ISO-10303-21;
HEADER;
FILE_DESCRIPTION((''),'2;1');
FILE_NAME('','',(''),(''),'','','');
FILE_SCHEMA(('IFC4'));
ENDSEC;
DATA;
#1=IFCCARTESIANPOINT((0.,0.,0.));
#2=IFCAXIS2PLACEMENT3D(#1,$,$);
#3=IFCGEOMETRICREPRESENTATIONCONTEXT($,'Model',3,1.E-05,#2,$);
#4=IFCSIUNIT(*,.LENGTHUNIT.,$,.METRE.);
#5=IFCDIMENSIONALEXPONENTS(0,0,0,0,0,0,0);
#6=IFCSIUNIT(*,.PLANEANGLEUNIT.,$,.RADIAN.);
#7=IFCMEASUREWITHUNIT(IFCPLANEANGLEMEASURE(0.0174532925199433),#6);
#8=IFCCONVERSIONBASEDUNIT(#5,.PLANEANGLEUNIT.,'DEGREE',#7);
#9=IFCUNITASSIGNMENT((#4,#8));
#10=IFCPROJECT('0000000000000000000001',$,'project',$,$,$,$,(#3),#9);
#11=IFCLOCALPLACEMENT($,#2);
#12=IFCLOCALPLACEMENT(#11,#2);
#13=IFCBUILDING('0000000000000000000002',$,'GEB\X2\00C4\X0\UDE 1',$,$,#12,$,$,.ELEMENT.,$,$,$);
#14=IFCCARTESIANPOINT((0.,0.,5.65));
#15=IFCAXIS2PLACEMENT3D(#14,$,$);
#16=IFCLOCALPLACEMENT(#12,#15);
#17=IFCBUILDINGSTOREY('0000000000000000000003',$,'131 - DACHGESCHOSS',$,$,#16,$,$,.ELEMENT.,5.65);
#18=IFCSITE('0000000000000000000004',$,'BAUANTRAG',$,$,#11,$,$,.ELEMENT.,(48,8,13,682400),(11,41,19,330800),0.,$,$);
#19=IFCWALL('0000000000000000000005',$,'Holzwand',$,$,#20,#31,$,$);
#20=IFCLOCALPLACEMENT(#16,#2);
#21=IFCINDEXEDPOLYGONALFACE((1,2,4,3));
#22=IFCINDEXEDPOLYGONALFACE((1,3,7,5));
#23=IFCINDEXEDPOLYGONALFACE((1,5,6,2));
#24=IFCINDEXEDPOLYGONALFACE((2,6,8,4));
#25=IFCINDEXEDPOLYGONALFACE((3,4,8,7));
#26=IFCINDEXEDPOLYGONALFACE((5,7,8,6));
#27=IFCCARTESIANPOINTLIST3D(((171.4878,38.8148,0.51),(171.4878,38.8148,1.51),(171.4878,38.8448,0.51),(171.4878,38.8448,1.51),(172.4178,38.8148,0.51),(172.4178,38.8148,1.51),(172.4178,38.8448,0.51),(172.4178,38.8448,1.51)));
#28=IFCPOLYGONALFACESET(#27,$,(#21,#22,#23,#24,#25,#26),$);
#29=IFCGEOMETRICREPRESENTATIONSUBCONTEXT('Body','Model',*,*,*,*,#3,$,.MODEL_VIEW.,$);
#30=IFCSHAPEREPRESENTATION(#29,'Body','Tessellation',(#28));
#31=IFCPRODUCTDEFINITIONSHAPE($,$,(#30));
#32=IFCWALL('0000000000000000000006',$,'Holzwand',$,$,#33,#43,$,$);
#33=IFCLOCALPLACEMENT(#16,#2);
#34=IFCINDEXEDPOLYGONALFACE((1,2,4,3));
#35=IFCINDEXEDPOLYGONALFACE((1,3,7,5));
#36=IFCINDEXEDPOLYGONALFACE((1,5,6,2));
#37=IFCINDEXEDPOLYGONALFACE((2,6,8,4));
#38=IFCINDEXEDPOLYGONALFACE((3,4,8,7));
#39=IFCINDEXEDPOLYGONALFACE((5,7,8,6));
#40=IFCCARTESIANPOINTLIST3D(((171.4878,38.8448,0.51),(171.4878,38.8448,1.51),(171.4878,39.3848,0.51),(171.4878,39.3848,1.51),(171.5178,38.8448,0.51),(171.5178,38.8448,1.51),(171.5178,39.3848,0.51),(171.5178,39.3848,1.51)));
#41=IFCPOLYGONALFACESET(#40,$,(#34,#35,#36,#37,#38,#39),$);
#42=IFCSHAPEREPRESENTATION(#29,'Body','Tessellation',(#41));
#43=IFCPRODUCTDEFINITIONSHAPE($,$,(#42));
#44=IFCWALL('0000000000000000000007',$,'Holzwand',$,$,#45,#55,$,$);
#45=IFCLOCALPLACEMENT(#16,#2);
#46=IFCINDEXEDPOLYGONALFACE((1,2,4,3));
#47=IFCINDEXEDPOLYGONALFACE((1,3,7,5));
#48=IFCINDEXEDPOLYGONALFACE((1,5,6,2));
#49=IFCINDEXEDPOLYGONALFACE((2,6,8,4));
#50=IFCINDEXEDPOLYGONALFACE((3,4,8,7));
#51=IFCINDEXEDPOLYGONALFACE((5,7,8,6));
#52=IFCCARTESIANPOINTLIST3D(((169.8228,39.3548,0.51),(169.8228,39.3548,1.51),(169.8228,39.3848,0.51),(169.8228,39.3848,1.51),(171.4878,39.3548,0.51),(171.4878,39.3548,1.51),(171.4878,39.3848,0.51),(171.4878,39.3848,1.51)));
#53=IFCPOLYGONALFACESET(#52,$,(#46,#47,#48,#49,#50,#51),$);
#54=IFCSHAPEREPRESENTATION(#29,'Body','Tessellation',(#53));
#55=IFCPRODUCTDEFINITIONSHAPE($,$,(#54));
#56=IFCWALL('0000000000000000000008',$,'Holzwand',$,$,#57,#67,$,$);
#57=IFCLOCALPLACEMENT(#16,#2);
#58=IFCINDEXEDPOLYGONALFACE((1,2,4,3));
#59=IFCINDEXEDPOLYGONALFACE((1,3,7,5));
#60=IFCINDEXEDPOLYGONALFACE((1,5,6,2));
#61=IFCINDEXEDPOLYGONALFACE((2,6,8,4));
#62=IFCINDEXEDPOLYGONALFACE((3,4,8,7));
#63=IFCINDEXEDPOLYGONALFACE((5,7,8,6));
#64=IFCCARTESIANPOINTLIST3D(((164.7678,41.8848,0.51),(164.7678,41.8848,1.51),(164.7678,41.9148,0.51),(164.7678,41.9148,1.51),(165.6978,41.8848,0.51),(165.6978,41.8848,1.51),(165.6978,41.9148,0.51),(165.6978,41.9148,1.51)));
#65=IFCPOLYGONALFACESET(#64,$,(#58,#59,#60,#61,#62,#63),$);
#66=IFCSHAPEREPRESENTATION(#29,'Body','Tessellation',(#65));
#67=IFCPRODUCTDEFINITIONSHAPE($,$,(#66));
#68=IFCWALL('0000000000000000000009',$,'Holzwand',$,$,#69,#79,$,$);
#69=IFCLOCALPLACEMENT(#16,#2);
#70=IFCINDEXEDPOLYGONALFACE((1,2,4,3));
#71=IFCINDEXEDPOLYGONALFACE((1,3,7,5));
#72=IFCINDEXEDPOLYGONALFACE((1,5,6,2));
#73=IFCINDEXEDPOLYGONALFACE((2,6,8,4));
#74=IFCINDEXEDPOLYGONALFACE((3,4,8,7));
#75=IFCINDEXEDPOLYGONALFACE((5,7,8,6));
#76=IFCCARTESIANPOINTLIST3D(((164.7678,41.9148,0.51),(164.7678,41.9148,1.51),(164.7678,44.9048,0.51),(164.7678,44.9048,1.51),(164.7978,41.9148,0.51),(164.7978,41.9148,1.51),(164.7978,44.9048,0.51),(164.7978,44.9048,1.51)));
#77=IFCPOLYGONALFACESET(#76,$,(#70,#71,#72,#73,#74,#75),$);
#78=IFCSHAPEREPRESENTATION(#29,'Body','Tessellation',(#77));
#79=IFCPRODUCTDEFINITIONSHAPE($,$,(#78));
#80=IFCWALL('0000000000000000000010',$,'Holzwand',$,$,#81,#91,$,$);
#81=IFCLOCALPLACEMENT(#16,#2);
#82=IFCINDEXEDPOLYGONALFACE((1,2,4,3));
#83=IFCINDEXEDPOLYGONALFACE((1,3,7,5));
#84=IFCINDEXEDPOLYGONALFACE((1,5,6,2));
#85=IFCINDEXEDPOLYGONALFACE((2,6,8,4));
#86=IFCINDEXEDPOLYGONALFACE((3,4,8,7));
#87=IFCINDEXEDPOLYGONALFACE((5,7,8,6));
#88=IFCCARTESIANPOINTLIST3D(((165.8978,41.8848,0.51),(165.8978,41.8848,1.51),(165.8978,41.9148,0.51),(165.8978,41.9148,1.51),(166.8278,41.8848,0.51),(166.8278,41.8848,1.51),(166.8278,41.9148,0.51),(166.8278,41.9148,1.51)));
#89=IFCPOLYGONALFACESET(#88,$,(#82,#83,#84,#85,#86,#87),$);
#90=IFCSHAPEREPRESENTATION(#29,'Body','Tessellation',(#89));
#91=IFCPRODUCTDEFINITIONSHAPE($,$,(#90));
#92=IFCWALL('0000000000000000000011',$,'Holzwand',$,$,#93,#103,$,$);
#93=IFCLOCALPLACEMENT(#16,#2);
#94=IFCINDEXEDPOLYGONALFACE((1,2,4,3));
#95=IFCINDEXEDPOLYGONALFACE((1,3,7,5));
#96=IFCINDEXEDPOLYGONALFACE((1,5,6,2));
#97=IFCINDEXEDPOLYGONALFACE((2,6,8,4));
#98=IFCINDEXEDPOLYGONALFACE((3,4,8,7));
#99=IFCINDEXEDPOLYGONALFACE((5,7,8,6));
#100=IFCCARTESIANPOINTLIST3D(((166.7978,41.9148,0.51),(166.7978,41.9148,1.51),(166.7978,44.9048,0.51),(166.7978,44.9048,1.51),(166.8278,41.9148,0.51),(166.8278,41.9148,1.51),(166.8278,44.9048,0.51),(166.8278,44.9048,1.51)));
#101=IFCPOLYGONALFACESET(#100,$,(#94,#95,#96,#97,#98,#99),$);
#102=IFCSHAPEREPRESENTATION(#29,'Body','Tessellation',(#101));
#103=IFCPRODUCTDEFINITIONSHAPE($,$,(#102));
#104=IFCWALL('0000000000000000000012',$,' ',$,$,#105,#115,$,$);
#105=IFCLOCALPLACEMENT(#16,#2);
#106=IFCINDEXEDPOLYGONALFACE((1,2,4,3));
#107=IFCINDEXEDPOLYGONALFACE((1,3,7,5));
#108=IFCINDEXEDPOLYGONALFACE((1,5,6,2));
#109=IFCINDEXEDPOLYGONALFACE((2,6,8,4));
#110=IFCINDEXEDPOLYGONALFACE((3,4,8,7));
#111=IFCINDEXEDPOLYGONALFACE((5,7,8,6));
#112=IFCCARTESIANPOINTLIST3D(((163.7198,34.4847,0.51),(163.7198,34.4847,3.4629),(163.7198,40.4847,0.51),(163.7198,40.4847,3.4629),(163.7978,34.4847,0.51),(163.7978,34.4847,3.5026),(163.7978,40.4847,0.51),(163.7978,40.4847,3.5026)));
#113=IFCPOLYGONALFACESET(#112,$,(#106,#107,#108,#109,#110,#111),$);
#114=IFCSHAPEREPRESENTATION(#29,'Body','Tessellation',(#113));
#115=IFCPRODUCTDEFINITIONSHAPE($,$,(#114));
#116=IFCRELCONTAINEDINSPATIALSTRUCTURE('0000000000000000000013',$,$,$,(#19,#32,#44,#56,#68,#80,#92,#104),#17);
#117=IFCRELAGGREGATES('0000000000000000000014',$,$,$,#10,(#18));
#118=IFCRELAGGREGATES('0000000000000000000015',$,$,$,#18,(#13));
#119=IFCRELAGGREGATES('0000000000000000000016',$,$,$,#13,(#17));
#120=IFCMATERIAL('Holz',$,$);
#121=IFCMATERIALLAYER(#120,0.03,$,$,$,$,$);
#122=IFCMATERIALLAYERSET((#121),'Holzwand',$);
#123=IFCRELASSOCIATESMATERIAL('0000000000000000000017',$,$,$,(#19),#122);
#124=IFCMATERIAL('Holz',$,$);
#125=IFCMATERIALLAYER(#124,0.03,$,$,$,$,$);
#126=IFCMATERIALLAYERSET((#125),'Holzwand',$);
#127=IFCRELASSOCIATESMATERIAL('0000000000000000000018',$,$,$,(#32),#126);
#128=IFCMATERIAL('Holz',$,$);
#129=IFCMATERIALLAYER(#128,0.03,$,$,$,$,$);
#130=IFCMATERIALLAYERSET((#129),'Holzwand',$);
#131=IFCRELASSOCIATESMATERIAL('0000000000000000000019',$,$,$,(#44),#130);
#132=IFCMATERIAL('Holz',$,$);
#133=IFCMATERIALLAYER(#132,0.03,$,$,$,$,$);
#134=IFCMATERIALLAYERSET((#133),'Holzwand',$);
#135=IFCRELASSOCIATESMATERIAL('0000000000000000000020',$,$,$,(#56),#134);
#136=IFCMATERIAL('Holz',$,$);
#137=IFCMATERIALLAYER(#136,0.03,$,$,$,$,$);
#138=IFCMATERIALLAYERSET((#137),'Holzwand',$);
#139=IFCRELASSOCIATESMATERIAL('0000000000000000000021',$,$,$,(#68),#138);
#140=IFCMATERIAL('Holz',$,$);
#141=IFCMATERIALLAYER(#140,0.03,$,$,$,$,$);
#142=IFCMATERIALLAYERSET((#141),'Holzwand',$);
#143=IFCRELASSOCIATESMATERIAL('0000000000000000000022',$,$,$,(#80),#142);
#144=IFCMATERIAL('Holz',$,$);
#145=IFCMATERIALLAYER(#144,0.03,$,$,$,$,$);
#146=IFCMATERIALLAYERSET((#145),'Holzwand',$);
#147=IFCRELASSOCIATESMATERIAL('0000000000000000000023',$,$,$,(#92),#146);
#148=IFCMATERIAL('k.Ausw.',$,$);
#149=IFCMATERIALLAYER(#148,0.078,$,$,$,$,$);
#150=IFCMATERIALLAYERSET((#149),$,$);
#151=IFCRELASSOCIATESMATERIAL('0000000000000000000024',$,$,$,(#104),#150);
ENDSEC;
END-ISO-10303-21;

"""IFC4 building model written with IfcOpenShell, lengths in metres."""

from ifc_helpers import new_model, entity, si_unit, converted_unit, frame, frame_2d, origin, origin_with_axes, place, context, subcontext, project, spatial, rectangle, extrude, clip, halfspace, material, layer, layer_set, layer_usage, element, save


model = new_model("IFC4")

# Units and contexts
model_context = context("Model", 3, precision=1e-05, world=origin())
body_context = subcontext(model_context, "Body", "Model", "MODEL_VIEW")
ifc_project = project(units=[si_unit("LENGTHUNIT", "METRE"), converted_unit("PLANEANGLEUNIT", "DEGREE", entity("IfcPlaneAngleMeasure", 0.0174532925199433), si_unit("PLANEANGLEUNIT", "RADIAN"), dimensions=[0, 0, 0, 0, 0, 0, 0])], contexts=[model_context])

# Site, building, storey
site_placement = place(None, origin())
site = spatial("IfcSite", under=ifc_project, at=site_placement, Name="BAUANTRAG", CompositionType="ELEMENT", RefLatitude=(48, 8, 13, 682400), RefLongitude=(11, 41, 19, 330800), RefElevation=0.0)
building_placement = place(site_placement, origin())
building = spatial("IfcBuilding", under=site, at=building_placement, Name="GEBÄUDE 1", CompositionType="ELEMENT")
storey_placement = place(building_placement, frame((0.0, 0.0, 5.65)))
storey = spatial("IfcBuildingStorey", under=building, at=storey_placement, Name="131 - DACHGESCHOSS", CompositionType="ELEMENT", Elevation=5.65)

# Walls
ifc_material_1 = material(Name="Holz")
ifc_layer_1 = layer(ifc_material_1, 0.03)
ifc_layer_set_1 = layer_set([ifc_layer_1], Name="Holzwand")
ifc_layer_usage_1 = layer_usage(ifc_layer_set_1, "AXIS2", "POSITIVE", 0.0)
wall_1_placement = place(storey_placement, frame((172.4178, 38.8448, 0.51), z_axis=(0.0, 0.0, 1.0), x_axis=(-1.0, 0.0, 0.0)))
element("IfcWall", 1, at=wall_1_placement, inside=storey, material=ifc_layer_usage_1, Name="Holzwand", context=body_context, shape_type="SweptSolid", body=[
    extrude(rectangle(XDim=0.93, YDim=0.03, at=frame_2d((0.465, 0.015), x_axis=(1.0, 0.0))), origin_with_axes(), (0.0, 0.0, 1.0), 1.0),
])
ifc_material_2 = material(Name="Holz")
ifc_layer_2 = layer(ifc_material_2, 0.03)
ifc_layer_set_2 = layer_set([ifc_layer_2], Name="Holzwand")
ifc_layer_usage_2 = layer_usage(ifc_layer_set_2, "AXIS2", "POSITIVE", 0.0)
wall_2_placement = place(storey_placement, frame((171.5178, 38.8448, 0.51), z_axis=(0.0, 0.0, 1.0), x_axis=(0.0, 1.0, 0.0)))
element("IfcWall", 2, at=wall_2_placement, inside=storey, material=ifc_layer_usage_2, Name="Holzwand", context=body_context, shape_type="SweptSolid", body=[
    extrude(rectangle(XDim=0.54, YDim=0.03, at=frame_2d((0.27, 0.015), x_axis=(1.0, 0.0))), origin_with_axes(), (0.0, 0.0, 1.0), 1.0),
])
ifc_material_3 = material(Name="Holz")
ifc_layer_3 = layer(ifc_material_3, 0.03)
ifc_layer_set_3 = layer_set([ifc_layer_3], Name="Holzwand")
ifc_layer_usage_3 = layer_usage(ifc_layer_set_3, "AXIS2", "POSITIVE", 0.0)
wall_3_placement = place(storey_placement, frame((171.4878, 39.3848, 0.51), z_axis=(0.0, 0.0, 1.0), x_axis=(-1.0, 0.0, 0.0)))
element("IfcWall", 3, at=wall_3_placement, inside=storey, material=ifc_layer_usage_3, Name="Holzwand", context=body_context, shape_type="SweptSolid", body=[
    extrude(rectangle(XDim=1.665, YDim=0.03, at=frame_2d((0.8325, 0.015), x_axis=(1.0, 0.0))), origin_with_axes(), (0.0, 0.0, 1.0), 1.0),
])
ifc_material_4 = material(Name="Holz")
ifc_layer_4 = layer(ifc_material_4, 0.03)
ifc_layer_set_4 = layer_set([ifc_layer_4], Name="Holzwand")
ifc_layer_usage_4 = layer_usage(ifc_layer_set_4, "AXIS2", "POSITIVE", 0.0)
wall_4_placement = place(storey_placement, frame((165.6978, 41.9148, 0.51), z_axis=(0.0, 0.0, 1.0), x_axis=(-1.0, 0.0, 0.0)))
element("IfcWall", 4, at=wall_4_placement, inside=storey, material=ifc_layer_usage_4, Name="Holzwand", context=body_context, shape_type="SweptSolid", body=[
    extrude(rectangle(XDim=0.93, YDim=0.03, at=frame_2d((0.465, 0.015), x_axis=(1.0, 0.0))), origin_with_axes(), (0.0, 0.0, 1.0), 1.0),
])
ifc_material_5 = material(Name="Holz")
ifc_layer_5 = layer(ifc_material_5, 0.03)
ifc_layer_set_5 = layer_set([ifc_layer_5], Name="Holzwand")
ifc_layer_usage_5 = layer_usage(ifc_layer_set_5, "AXIS2", "POSITIVE", 0.0)
wall_5_placement = place(storey_placement, frame((164.7978, 41.9148, 0.51), z_axis=(0.0, 0.0, 1.0), x_axis=(0.0, 1.0, 0.0)))
element("IfcWall", 5, at=wall_5_placement, inside=storey, material=ifc_layer_usage_5, Name="Holzwand", context=body_context, shape_type="SweptSolid", body=[
    extrude(rectangle(XDim=2.99, YDim=0.03, at=frame_2d((1.495, 0.015), x_axis=(1.0, 0.0))), origin_with_axes(), (0.0, 0.0, 1.0), 1.0),
])
ifc_material_6 = material(Name="Holz")
ifc_layer_6 = layer(ifc_material_6, 0.03)
ifc_layer_set_6 = layer_set([ifc_layer_6], Name="Holzwand")
ifc_layer_usage_6 = layer_usage(ifc_layer_set_6, "AXIS2", "POSITIVE", 0.0)
wall_6_placement = place(storey_placement, frame((166.8278, 41.9148, 0.51), z_axis=(0.0, 0.0, 1.0), x_axis=(-1.0, 0.0, 0.0)))
element("IfcWall", 6, at=wall_6_placement, inside=storey, material=ifc_layer_usage_6, Name="Holzwand", context=body_context, shape_type="SweptSolid", body=[
    extrude(rectangle(XDim=0.93, YDim=0.03, at=frame_2d((0.465, 0.015), x_axis=(1.0, 0.0))), origin_with_axes(), (0.0, 0.0, 1.0), 1.0),
])
ifc_material_7 = material(Name="Holz")
ifc_layer_7 = layer(ifc_material_7, 0.03)
ifc_layer_set_7 = layer_set([ifc_layer_7], Name="Holzwand")
ifc_layer_usage_7 = layer_usage(ifc_layer_set_7, "AXIS2", "POSITIVE", 0.0)
wall_7_placement = place(storey_placement, frame((166.7978, 44.9048, 0.51), z_axis=(0.0, 0.0, 1.0), x_axis=(0.0, -1.0, 0.0)))
element("IfcWall", 7, at=wall_7_placement, inside=storey, material=ifc_layer_usage_7, Name="Holzwand", context=body_context, shape_type="SweptSolid", body=[
    extrude(rectangle(XDim=2.99, YDim=0.03, at=frame_2d((1.495, 0.015), x_axis=(1.0, 0.0))), origin_with_axes(), (0.0, 0.0, 1.0), 1.0),
])
ifc_material_8 = material(Name="k.Ausw.")
ifc_layer_8 = layer(ifc_material_8, 0.078)
ifc_layer_set_8 = layer_set([ifc_layer_8])
ifc_layer_usage_8 = layer_usage(ifc_layer_set_8, "AXIS2", "POSITIVE", 0.0)
wall_8_placement = place(storey_placement, frame((163.7198, 40.4847, 0.51), z_axis=(0.0, 0.0, 1.0), x_axis=(0.0, -1.0, 0.0)))
element("IfcWall", 8, at=wall_8_placement, inside=storey, material=ifc_layer_usage_8, Name=" ", context=body_context, shape_type="Clipping", body=[
    clip(extrude(rectangle(XDim=6.0, YDim=0.078, at=frame_2d((3.0, 0.039), x_axis=(1.0, 0.0))), origin_with_axes(), (0.0, 0.0, 1.0), 2.9926), halfspace(frame((3.0, 0.039, 2.9728), z_axis=(0.0, 0.45399, -0.891007), x_axis=(1.0, 0.0, 0.0)), True)),
])

save(model, "model.ifc")
